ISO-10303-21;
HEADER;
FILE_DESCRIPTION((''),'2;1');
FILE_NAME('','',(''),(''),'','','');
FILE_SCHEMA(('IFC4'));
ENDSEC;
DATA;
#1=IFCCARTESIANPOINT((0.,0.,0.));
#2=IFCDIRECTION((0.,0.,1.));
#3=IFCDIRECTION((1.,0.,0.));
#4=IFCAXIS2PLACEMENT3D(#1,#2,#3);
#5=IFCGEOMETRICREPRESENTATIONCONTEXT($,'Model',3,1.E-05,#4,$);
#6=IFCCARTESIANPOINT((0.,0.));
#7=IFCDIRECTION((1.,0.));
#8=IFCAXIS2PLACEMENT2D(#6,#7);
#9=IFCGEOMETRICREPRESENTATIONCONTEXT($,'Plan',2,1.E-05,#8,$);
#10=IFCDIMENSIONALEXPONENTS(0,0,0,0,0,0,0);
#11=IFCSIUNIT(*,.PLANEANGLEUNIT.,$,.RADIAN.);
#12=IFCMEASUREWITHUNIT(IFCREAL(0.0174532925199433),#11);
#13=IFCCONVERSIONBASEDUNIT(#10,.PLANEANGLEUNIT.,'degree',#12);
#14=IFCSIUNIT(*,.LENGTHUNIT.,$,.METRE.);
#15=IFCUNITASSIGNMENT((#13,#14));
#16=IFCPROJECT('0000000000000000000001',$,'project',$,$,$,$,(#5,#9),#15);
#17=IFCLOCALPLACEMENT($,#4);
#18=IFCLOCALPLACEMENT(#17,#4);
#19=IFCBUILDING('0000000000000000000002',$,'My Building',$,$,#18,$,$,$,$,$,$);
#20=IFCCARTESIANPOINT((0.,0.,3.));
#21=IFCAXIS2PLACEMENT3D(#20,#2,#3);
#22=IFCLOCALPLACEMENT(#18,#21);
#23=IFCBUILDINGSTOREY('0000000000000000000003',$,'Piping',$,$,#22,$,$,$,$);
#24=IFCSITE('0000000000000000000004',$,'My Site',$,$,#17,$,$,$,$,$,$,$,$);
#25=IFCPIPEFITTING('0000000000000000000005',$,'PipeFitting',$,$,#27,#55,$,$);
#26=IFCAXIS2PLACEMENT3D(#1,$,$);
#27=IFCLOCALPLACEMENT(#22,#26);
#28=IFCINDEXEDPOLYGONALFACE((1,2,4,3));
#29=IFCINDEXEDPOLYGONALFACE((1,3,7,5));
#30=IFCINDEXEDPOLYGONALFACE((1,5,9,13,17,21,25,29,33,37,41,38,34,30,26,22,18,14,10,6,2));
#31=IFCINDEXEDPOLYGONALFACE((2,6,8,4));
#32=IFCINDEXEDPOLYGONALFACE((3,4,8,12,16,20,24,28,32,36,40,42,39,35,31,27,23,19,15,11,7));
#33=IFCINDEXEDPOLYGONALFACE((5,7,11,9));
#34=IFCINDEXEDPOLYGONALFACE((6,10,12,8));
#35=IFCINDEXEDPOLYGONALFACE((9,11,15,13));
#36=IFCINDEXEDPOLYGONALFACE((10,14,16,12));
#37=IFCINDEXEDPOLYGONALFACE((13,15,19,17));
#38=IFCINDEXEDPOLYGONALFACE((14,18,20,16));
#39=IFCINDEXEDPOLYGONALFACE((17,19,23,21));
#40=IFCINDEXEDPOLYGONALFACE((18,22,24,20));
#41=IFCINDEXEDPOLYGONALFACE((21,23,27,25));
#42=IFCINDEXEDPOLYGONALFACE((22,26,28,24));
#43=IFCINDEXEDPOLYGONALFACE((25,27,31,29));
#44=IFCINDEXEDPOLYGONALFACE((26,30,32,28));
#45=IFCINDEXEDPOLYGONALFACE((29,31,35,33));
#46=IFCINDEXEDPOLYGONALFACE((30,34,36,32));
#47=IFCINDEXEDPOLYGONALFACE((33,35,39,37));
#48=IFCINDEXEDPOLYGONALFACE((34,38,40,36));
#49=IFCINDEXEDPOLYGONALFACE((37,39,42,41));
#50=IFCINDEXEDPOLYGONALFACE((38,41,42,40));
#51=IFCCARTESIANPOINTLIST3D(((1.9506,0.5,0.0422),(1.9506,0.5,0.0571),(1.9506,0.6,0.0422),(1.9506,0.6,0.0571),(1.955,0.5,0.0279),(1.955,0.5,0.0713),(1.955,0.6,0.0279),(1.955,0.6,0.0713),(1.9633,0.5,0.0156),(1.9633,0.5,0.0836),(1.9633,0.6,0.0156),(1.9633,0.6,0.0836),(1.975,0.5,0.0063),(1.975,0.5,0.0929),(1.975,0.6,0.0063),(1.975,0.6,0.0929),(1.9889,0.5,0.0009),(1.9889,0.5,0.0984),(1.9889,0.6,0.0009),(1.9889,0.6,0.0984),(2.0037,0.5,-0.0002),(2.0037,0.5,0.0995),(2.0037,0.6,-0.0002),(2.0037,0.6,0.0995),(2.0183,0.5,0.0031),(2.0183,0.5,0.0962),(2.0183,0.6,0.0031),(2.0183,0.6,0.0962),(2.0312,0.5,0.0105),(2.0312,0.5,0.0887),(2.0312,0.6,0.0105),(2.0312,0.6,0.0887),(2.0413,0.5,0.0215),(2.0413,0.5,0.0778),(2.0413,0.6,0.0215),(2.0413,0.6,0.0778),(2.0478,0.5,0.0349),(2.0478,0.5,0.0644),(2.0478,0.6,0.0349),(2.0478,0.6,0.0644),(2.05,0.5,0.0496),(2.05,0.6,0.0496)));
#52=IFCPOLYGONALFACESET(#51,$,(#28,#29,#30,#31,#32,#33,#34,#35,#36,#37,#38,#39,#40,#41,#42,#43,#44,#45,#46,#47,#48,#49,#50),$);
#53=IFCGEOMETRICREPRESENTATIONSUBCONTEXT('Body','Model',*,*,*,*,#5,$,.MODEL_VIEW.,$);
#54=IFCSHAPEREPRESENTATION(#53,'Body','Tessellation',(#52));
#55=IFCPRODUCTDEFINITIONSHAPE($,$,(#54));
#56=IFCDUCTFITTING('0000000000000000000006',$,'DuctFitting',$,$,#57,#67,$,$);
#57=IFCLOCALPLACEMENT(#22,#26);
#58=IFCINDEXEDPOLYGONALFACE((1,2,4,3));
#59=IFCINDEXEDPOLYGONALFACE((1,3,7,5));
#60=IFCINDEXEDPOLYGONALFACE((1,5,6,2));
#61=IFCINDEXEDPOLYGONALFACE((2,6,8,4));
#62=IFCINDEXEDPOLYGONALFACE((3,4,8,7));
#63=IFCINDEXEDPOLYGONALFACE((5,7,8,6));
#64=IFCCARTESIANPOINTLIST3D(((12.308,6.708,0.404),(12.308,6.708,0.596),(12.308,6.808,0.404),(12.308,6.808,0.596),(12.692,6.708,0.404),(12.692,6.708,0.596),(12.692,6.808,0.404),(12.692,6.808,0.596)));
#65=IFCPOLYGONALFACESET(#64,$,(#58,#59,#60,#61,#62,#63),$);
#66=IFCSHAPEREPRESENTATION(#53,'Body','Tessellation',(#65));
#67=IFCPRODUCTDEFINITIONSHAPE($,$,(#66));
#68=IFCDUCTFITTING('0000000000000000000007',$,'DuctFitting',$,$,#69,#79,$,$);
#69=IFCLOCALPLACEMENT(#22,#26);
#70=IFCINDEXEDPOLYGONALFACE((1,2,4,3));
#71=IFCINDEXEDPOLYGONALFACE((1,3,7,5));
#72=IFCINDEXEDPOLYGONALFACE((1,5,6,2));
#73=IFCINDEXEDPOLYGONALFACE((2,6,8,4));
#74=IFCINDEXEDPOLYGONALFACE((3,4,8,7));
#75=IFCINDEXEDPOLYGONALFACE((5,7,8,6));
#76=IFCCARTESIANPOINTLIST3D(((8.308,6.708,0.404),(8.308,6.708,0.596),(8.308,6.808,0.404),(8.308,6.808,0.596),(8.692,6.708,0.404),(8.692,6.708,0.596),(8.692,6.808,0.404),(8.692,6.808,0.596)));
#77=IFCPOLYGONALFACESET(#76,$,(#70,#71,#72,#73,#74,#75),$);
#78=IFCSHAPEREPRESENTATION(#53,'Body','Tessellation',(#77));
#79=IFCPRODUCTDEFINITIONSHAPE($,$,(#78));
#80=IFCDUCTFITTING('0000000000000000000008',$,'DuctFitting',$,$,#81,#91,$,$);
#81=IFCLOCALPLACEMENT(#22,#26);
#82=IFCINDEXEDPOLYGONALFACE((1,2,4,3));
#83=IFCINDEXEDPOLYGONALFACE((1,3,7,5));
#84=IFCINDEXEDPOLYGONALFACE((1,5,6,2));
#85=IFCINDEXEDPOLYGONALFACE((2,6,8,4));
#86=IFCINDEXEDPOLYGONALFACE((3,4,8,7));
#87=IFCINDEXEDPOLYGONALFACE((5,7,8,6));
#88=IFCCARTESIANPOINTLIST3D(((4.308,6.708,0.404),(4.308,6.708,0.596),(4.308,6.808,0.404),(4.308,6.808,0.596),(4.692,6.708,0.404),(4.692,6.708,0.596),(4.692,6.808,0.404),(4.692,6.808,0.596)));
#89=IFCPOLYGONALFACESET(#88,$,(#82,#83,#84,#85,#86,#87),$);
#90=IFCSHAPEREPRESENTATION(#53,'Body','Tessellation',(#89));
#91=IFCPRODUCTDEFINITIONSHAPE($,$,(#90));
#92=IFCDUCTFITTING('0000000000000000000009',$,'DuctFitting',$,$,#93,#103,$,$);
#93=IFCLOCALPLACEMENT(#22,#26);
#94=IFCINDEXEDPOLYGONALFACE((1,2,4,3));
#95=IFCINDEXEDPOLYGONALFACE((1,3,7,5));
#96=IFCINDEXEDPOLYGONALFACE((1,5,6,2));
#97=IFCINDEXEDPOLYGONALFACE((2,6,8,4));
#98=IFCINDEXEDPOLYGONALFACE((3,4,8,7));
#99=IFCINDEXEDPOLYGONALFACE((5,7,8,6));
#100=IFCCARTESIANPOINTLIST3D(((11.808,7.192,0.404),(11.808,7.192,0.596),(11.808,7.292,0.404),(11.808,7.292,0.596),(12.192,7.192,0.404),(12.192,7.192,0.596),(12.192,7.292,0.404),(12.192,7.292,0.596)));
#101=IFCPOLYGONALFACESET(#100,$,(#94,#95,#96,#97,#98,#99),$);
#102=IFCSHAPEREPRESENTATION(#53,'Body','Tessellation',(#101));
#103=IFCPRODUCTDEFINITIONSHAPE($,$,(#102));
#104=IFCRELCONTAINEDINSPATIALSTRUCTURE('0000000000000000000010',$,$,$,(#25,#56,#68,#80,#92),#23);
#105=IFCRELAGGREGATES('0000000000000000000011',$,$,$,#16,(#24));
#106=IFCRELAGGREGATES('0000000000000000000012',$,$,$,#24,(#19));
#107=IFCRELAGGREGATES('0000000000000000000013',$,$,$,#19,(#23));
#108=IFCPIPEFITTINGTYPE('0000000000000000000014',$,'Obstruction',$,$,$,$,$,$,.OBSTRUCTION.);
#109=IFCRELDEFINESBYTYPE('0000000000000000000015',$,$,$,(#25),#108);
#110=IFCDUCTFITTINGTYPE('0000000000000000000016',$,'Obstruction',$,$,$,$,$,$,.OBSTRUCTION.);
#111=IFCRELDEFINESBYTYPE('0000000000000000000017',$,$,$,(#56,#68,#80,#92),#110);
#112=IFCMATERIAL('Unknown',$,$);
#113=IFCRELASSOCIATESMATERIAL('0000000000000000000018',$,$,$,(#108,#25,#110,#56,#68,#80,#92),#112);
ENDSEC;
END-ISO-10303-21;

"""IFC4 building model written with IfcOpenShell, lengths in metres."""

from ifc_helpers import new_model, entity, si_unit, converted_unit, frame, origin_with_axes, origin_2d_with_axis, place, context, subcontext, project, spatial, indexed_curve, circle, outline, extrude, material, material_profile, profile_set, profile_usage, type_object, element, save


model = new_model("IFC4")

# Units and contexts
model_context = context("Model", 3, precision=1e-05, world=origin_with_axes())
plan_context = context("Plan", 2, precision=1e-05, world=origin_2d_with_axis())
body_context = subcontext(model_context, "Body", "Model", "MODEL_VIEW")
ifc_project = project(units=[converted_unit("PLANEANGLEUNIT", "degree", entity("IfcReal", 0.0174532925199433), si_unit("PLANEANGLEUNIT", "RADIAN"), dimensions=[0, 0, 0, 0, 0, 0, 0]), si_unit("LENGTHUNIT", "METRE")], contexts=[model_context, plan_context])

# Site, building, storey
site_placement = place(None, origin_with_axes())
site = spatial("IfcSite", under=ifc_project, at=site_placement, Name="My Site")
building_placement = place(site_placement, origin_with_axes())
building = spatial("IfcBuilding", under=site, at=building_placement, Name="My Building")
storey_placement = place(building_placement, frame((0.0, 0.0, 3.0), z_axis=(0.0, 0.0, 1.0), x_axis=(1.0, 0.0, 0.0)))
storey = spatial("IfcBuildingStorey", under=building, at=storey_placement, Name="Piping")

# Shared definitions
ifc_material = material(Name="Unknown")

# Pipe fitting
ifc_material_profile_1 = material_profile(ifc_material, circle(Radius=0.05))
ifc_profile_set_1 = profile_set([ifc_material_profile_1])
pipe_fitting_type_1 = type_object("IfcPipeFittingType", Name="Obstruction", PredefinedType="OBSTRUCTION", material=ifc_profile_set_1)
ifc_profile_usage_1 = profile_usage(ifc_profile_set_1, cardinal=5)
pipe_fitting_1_placement = place(storey_placement, frame((2.0, 0.6, 0.0496), z_axis=(0.0, -1.0, 0.0), x_axis=(1.0, 0.0, 0.0)))
element("IfcPipeFitting", 1, at=pipe_fitting_1_placement, inside=storey, type_object=pipe_fitting_type_1, material=ifc_profile_usage_1, Name="PipeFitting", context=body_context, shape_type="SweptSolid", body=[
    extrude(circle(Radius=0.05), origin_with_axes(), (0.0, 0.0, 1.0), 0.1),
])

# Duct fittings
ifc_material_profile_2 = material_profile(ifc_material, outline(indexed_curve([(-0.192, -0.096), (0.192, -0.096), (0.192, 0.096), (-0.192, 0.096), (-0.192, -0.096)])))
ifc_profile_set_2 = profile_set([ifc_material_profile_2])
ifc_profile_usage_2 = profile_usage(ifc_profile_set_2, cardinal=5)
duct_fitting_type = type_object("IfcDuctFittingType", Name="Obstruction", PredefinedType="OBSTRUCTION", material=ifc_profile_set_2)
duct_fitting_1_placement = place(storey_placement, frame((12.5, 6.808, 0.5), z_axis=(0.0, -1.0, 0.0), x_axis=(1.0, 0.0, 0.0)))
element("IfcDuctFitting", 2, at=duct_fitting_1_placement, inside=storey, type_object=duct_fitting_type, material=ifc_profile_usage_2, Name="DuctFitting", context=body_context, shape_type="SweptSolid", body=[
    extrude(outline(indexed_curve([(-0.192, -0.096), (0.192, -0.096), (0.192, 0.096), (-0.192, 0.096), (-0.192, -0.096)])), origin_with_axes(), (0.0, 0.0, 1.0), 0.1),
])
ifc_profile_usage_3 = profile_usage(ifc_profile_set_2, cardinal=5)
duct_fitting_2_placement = place(storey_placement, frame((8.5, 6.808, 0.5), z_axis=(0.0, -1.0, 0.0), x_axis=(1.0, 0.0, 0.0)))
element("IfcDuctFitting", 3, at=duct_fitting_2_placement, inside=storey, type_object=duct_fitting_type, material=ifc_profile_usage_3, Name="DuctFitting", context=body_context, shape_type="SweptSolid", body=[
    extrude(outline(indexed_curve([(-0.192, -0.096), (0.192, -0.096), (0.192, 0.096), (-0.192, 0.096), (-0.192, -0.096)])), origin_with_axes(), (0.0, 0.0, 1.0), 0.1),
])
ifc_profile_usage_4 = profile_usage(ifc_profile_set_2, cardinal=5)
duct_fitting_3_placement = place(storey_placement, frame((4.5, 6.808, 0.5), z_axis=(0.0, -1.0, 0.0), x_axis=(1.0, 0.0, 0.0)))
element("IfcDuctFitting", 4, at=duct_fitting_3_placement, inside=storey, type_object=duct_fitting_type, material=ifc_profile_usage_4, Name="DuctFitting", context=body_context, shape_type="SweptSolid", body=[
    extrude(outline(indexed_curve([(-0.192, -0.096), (0.192, -0.096), (0.192, 0.096), (-0.192, 0.096), (-0.192, -0.096)])), origin_with_axes(), (0.0, 0.0, 1.0), 0.1),
])
ifc_profile_usage_5 = profile_usage(ifc_profile_set_2, cardinal=5)
duct_fitting_4_placement = place(storey_placement, frame((12.0, 7.192, 0.5), z_axis=(0.0, 1.0, 0.0), x_axis=(-1.0, 0.0, 0.0)))
element("IfcDuctFitting", 5, at=duct_fitting_4_placement, inside=storey, type_object=duct_fitting_type, material=ifc_profile_usage_5, Name="DuctFitting", context=body_context, shape_type="SweptSolid", body=[
    extrude(outline(indexed_curve([(-0.192, -0.096), (0.192, -0.096), (0.192, 0.096), (-0.192, 0.096), (-0.192, -0.096)])), origin_with_axes(), (0.0, 0.0, 1.0), 0.1),
])

save(model, "model.ifc")
